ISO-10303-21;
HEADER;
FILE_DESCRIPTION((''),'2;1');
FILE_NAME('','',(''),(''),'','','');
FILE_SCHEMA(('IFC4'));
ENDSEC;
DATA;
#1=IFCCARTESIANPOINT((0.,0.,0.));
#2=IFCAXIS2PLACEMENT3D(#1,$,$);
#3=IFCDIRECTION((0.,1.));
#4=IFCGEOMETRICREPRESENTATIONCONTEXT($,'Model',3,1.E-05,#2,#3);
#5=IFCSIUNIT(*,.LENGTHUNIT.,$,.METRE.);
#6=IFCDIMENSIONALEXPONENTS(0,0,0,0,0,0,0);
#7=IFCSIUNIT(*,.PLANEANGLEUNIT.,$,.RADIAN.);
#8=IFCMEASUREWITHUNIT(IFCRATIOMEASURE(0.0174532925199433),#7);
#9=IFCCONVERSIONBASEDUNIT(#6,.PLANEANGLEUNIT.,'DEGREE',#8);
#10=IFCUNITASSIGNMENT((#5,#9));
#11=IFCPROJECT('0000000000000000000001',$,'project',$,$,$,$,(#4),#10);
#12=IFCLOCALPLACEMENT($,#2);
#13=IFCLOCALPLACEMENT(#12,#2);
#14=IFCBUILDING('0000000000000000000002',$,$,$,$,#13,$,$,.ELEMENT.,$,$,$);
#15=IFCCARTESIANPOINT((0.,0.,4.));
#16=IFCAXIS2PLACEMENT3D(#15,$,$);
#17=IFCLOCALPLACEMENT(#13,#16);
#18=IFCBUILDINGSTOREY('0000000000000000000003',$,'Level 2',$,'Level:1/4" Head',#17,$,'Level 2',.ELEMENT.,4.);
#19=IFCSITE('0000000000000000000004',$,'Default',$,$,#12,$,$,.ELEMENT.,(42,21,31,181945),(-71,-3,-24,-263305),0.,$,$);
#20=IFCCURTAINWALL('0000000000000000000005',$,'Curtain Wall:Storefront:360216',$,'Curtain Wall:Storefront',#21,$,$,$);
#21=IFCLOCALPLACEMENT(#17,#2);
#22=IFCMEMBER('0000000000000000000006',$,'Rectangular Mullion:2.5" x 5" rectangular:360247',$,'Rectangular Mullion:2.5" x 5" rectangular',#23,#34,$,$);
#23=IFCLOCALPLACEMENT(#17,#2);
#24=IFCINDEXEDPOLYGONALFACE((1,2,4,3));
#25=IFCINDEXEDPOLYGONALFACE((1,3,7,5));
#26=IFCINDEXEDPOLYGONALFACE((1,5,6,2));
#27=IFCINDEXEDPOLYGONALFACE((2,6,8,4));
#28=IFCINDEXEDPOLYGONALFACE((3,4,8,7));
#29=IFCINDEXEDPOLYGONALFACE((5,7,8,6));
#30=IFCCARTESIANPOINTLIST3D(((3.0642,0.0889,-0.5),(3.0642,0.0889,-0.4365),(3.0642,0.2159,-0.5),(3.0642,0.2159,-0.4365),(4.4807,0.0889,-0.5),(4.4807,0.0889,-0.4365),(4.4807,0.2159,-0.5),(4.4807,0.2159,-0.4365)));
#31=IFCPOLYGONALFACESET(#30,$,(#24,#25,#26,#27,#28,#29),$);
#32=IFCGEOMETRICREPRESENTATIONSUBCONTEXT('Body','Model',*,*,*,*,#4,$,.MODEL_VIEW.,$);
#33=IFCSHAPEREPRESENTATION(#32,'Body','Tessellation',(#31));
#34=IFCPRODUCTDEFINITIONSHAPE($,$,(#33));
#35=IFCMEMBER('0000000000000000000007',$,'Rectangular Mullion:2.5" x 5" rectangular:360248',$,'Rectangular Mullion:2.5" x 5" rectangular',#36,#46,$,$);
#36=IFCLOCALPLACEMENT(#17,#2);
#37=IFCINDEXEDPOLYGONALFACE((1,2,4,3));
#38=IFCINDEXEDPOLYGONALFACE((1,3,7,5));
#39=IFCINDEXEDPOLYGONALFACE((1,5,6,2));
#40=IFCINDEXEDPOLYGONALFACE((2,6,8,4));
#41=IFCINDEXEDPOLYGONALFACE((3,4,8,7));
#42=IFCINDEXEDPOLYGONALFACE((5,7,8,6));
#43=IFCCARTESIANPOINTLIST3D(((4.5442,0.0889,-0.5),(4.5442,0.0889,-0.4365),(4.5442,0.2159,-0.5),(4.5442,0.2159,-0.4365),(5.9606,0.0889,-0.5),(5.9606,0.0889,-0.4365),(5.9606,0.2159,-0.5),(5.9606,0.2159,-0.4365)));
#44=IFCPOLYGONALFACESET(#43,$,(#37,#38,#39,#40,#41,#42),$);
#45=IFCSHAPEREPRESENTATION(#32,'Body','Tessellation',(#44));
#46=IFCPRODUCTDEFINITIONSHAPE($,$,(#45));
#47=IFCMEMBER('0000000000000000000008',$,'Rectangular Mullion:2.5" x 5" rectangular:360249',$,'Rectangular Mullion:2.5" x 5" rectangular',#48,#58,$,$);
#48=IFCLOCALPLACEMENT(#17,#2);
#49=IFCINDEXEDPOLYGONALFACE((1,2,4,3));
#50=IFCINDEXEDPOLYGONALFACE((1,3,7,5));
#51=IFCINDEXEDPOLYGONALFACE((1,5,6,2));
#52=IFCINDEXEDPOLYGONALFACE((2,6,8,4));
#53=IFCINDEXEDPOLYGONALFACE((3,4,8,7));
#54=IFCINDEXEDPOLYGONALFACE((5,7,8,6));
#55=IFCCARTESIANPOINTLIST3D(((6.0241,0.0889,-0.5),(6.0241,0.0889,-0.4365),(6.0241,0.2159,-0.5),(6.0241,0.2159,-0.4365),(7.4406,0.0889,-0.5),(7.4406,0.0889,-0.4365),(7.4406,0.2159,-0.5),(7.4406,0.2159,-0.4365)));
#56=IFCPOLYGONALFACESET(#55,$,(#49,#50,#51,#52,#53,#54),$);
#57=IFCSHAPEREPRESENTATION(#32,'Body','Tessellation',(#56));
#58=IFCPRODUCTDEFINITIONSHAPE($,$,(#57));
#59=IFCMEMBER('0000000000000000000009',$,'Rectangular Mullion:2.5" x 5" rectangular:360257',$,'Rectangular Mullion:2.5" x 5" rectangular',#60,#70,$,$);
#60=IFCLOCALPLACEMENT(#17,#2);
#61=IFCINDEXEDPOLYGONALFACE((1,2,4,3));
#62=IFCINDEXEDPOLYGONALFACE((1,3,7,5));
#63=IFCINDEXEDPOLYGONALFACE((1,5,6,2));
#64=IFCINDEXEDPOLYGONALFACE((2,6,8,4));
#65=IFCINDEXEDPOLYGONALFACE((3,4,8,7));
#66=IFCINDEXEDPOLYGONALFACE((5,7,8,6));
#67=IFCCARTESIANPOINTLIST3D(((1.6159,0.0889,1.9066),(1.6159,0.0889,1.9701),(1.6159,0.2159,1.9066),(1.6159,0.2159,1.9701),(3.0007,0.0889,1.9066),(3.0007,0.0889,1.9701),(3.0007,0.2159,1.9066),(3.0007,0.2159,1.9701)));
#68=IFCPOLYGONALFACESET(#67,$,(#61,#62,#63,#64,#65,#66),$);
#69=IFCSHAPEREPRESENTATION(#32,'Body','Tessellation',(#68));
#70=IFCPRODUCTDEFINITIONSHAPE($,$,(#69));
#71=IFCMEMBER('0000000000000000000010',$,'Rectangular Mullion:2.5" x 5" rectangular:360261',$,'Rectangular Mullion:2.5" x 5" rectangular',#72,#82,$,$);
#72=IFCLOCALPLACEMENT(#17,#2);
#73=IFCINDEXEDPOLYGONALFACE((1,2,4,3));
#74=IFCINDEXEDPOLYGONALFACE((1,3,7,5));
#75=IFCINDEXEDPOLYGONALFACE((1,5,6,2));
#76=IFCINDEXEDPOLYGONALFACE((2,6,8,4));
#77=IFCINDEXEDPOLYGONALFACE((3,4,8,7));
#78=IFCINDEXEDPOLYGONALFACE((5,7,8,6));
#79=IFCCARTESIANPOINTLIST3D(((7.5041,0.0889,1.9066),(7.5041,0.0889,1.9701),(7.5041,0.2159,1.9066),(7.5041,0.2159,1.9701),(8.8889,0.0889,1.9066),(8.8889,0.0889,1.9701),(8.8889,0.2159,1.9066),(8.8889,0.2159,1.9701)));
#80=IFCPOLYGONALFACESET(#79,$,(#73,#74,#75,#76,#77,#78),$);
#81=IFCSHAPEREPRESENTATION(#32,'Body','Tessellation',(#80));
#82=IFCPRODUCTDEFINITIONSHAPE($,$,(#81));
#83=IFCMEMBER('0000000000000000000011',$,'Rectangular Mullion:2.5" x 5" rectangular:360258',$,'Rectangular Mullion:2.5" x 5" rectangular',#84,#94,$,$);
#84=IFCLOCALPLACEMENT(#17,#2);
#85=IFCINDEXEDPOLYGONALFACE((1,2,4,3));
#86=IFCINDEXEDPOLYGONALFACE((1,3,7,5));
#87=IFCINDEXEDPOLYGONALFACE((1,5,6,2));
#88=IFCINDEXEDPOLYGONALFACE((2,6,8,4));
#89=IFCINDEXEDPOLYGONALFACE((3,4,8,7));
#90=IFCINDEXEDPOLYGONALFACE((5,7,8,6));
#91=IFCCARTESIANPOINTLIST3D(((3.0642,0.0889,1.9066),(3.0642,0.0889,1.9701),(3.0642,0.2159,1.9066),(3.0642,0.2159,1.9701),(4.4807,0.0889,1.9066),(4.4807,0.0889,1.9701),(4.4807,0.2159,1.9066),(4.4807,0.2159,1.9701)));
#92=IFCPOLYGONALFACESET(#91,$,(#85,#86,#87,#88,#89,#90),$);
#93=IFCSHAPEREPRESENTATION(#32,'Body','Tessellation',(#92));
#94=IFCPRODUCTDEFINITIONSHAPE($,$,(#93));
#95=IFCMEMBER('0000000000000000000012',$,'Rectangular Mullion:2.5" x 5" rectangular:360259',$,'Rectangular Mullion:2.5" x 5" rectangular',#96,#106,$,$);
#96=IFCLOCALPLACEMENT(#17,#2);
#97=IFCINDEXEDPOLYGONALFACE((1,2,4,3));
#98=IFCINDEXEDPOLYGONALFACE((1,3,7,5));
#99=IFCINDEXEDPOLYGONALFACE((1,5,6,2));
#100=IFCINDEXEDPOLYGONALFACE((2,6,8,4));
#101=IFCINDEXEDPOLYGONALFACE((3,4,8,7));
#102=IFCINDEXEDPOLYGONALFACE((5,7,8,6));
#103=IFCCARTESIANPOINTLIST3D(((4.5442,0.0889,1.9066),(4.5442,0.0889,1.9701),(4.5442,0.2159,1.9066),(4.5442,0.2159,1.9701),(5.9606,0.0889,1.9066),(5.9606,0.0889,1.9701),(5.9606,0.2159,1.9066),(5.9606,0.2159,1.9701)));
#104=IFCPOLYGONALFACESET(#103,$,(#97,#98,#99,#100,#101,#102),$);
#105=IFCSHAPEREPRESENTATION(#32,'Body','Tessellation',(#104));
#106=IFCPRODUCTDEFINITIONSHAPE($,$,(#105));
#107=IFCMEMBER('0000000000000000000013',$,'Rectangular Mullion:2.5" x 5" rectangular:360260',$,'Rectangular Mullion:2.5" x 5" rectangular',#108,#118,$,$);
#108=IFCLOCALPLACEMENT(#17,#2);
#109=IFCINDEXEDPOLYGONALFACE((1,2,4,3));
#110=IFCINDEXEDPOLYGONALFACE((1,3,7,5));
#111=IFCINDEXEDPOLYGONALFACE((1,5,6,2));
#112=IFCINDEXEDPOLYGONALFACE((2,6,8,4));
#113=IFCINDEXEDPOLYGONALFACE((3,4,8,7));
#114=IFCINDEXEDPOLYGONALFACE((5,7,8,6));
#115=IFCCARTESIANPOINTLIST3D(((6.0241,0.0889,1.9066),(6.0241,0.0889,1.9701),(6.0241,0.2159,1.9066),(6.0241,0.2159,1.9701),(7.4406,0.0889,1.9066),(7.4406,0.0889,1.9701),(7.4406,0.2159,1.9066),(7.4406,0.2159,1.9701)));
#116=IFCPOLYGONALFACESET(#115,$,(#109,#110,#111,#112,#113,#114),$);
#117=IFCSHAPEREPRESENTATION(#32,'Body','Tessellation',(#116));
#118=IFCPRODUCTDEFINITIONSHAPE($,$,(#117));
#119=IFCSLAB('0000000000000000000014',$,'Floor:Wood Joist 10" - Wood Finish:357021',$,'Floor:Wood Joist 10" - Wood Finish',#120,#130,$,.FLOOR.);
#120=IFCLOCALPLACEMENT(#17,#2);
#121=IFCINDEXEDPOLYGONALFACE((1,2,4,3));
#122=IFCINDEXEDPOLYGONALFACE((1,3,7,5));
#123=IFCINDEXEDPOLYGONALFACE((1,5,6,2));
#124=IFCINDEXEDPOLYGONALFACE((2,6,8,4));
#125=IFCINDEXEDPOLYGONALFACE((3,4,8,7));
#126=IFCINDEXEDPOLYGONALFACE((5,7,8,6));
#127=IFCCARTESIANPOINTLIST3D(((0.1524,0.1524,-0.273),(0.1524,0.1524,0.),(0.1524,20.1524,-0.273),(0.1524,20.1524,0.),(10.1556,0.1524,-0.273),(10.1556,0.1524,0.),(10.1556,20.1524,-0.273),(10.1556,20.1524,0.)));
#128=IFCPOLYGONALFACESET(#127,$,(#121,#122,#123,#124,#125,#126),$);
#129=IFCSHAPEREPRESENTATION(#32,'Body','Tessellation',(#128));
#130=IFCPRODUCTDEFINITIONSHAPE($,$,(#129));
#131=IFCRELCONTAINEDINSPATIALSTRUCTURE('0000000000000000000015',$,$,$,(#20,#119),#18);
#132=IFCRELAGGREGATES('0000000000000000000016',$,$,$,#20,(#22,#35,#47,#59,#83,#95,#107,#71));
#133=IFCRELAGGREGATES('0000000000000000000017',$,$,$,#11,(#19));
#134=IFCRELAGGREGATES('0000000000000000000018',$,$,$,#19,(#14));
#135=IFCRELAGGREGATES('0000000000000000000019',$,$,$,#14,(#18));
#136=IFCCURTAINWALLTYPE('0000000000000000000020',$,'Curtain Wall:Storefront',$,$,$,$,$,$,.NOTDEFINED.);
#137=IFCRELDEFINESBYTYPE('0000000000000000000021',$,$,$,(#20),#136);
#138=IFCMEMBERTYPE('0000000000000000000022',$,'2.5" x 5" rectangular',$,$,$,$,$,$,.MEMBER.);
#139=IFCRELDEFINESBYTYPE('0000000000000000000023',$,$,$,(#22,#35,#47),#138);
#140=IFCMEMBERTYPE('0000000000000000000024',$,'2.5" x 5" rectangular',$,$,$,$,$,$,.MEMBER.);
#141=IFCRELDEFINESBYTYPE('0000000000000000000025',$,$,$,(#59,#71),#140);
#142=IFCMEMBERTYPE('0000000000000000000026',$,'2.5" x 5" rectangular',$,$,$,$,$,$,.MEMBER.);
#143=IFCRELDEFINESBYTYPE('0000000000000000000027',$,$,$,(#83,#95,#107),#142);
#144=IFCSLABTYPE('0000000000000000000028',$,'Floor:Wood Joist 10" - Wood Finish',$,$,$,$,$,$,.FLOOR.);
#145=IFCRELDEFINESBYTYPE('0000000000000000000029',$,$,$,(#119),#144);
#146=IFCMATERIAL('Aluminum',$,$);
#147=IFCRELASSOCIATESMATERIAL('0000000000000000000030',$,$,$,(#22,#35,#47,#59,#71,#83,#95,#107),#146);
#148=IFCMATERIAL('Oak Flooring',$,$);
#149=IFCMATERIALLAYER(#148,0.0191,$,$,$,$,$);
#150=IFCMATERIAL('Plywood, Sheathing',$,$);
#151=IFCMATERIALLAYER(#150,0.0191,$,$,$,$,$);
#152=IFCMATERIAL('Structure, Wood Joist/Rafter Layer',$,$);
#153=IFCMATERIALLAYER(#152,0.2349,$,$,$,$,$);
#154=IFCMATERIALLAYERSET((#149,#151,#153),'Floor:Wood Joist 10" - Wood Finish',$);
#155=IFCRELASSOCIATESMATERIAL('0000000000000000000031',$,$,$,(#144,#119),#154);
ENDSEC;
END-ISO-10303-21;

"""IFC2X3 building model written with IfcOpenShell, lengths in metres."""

from ifc_helpers import new_model, entity, si_unit, converted_unit, direction, frame, origin, origin_2d_with_axis, place, context, subcontext, project, spatial, rectangle, extrude, source, transform, mapped, material, layer, layer_set, layer_usage, type_object, type_shapes, element, aggregate, save


model = new_model("IFC2X3")

# Units and contexts
model_context = context("Model", 3, precision=1e-05, world=origin(), true_north=direction((0.0, 1.0)))
body_context = subcontext(model_context, "Body", "Model", "MODEL_VIEW")
ifc_project = project(units=[si_unit("LENGTHUNIT", "METRE"), converted_unit("PLANEANGLEUNIT", "DEGREE", entity("IfcRatioMeasure", 0.0174532925199433), si_unit("PLANEANGLEUNIT", "RADIAN"), dimensions=[0, 0, 0, 0, 0, 0, 0])], contexts=[model_context])

# Site, building, storey
site_placement = place(None, origin())
site = spatial("IfcSite", under=ifc_project, at=site_placement, Name="Default", CompositionType="ELEMENT", RefLatitude=(42, 21, 31, 181945), RefLongitude=(-71, -3, -24, -263305), RefElevation=0.0)
building_placement = place(site_placement, origin())
building = spatial("IfcBuilding", under=site, at=building_placement, CompositionType="ELEMENT")
storey_placement = place(building_placement, frame((0.0, 0.0, 4.0)))
storey = spatial("IfcBuildingStorey", under=building, at=storey_placement, Name="Level 2", ObjectType="Level:1/4\" Head", LongName="Level 2", CompositionType="ELEMENT", Elevation=4.0)

# Curtain wall, members
curtain_wall_type = type_object("IfcCurtainWallType", Name="Curtain Wall:Storefront", PredefinedType="NOTDEFINED")
curtain_wall_placement = place(storey_placement, frame((0.0, 0.0, -4.0)))
curtain_wall = element("IfcCurtainWall", 1, at=curtain_wall_placement, inside=storey, type_object=curtain_wall_type, Name="Curtain Wall:Storefront:360216", ObjectType="Curtain Wall:Storefront")
ifc_material_1 = material(Name="Aluminum")
member_type_1 = type_object("IfcMemberType", Name="2.5\" x 5\" rectangular", PredefinedType="MEMBER")
shared_shape_1 = source(origin(), body_context, "Body", "SweptSolid", [
    extrude(rectangle(XDim=0.127, YDim=0.0635, at=origin_2d_with_axis()), frame((-0.0318, 0.0, -1.4165), z_axis=(0.0, 0.0, 1.0), x_axis=(0.0, -1.0, 0.0)), (0.0, 0.0, 1.0), 1.4165),
])
type_shapes(member_type_1, [shared_shape_1])
member_1_placement = place(storey_placement, frame((3.0642, 0.1524, -0.5), z_axis=(-1.0, 0.0, 0.0), x_axis=(0.0, 0.0, -1.0)))
member_1 = element("IfcMember", 2, at=member_1_placement, type_object=member_type_1, material=ifc_material_1, Name="Rectangular Mullion:2.5\" x 5\" rectangular:360247", ObjectType="Rectangular Mullion:2.5\" x 5\" rectangular", context=body_context, shape_type="MappedRepresentation", body=[
    mapped(shared_shape_1, transform((0.0, 0.0, 0.0), scale=1.0)),
])
member_2_placement = place(storey_placement, frame((4.5442, 0.1524, -0.5), z_axis=(-1.0, 0.0, 0.0), x_axis=(0.0, 0.0, -1.0)))
member_2 = element("IfcMember", 3, at=member_2_placement, type_object=member_type_1, material=ifc_material_1, Name="Rectangular Mullion:2.5\" x 5\" rectangular:360248", ObjectType="Rectangular Mullion:2.5\" x 5\" rectangular", context=body_context, shape_type="MappedRepresentation", body=[
    mapped(shared_shape_1, transform((0.0, 0.0, 0.0), scale=1.0)),
])
member_3_placement = place(storey_placement, frame((6.0241, 0.1524, -0.5), z_axis=(-1.0, 0.0, 0.0), x_axis=(0.0, 0.0, -1.0)))
member_3 = element("IfcMember", 4, at=member_3_placement, type_object=member_type_1, material=ifc_material_1, Name="Rectangular Mullion:2.5\" x 5\" rectangular:360249", ObjectType="Rectangular Mullion:2.5\" x 5\" rectangular", context=body_context, shape_type="MappedRepresentation", body=[
    mapped(shared_shape_1, transform((0.0, 0.0, 0.0), scale=1.0)),
])
member_type_2 = type_object("IfcMemberType", Name="2.5\" x 5\" rectangular", PredefinedType="MEMBER")
shared_shape_2 = source(origin(), body_context, "Body", "SweptSolid", [
    extrude(rectangle(XDim=0.127, YDim=0.0635, at=origin_2d_with_axis()), frame((0.0, 0.0, -1.3848), z_axis=(0.0, 0.0, 1.0), x_axis=(0.0, -1.0, 0.0)), (0.0, 0.0, 1.0), 1.3848),
])
type_shapes(member_type_2, [shared_shape_2])
member_4_placement = place(storey_placement, frame((3.0007, 0.1524, 1.9384), z_axis=(1.0, 0.0, 0.0), x_axis=(0.0, 0.0, 1.0)))
member_4 = element("IfcMember", 5, at=member_4_placement, type_object=member_type_2, material=ifc_material_1, Name="Rectangular Mullion:2.5\" x 5\" rectangular:360257", ObjectType="Rectangular Mullion:2.5\" x 5\" rectangular", context=body_context, shape_type="MappedRepresentation", body=[
    mapped(shared_shape_2, transform((0.0, 0.0, 0.0), scale=1.0)),
])
member_5_placement = place(storey_placement, frame((8.8889, 0.1524, 1.9384), z_axis=(1.0, 0.0, 0.0), x_axis=(0.0, 0.0, 1.0)))
member_5 = element("IfcMember", 6, at=member_5_placement, type_object=member_type_2, material=ifc_material_1, Name="Rectangular Mullion:2.5\" x 5\" rectangular:360261", ObjectType="Rectangular Mullion:2.5\" x 5\" rectangular", context=body_context, shape_type="MappedRepresentation", body=[
    mapped(shared_shape_2, transform((0.0, 0.0, 0.0), scale=1.0)),
])
member_type_3 = type_object("IfcMemberType", Name="2.5\" x 5\" rectangular", PredefinedType="MEMBER")
shared_shape_3 = source(origin(), body_context, "Body", "SweptSolid", [
    extrude(rectangle(XDim=0.127, YDim=0.0635, at=origin_2d_with_axis()), frame((0.0, 0.0, -1.4165), z_axis=(0.0, 0.0, 1.0), x_axis=(0.0, -1.0, 0.0)), (0.0, 0.0, 1.0), 1.4165),
])
type_shapes(member_type_3, [shared_shape_3])
member_6_placement = place(storey_placement, frame((4.4807, 0.1524, 1.9384), z_axis=(1.0, 0.0, 0.0), x_axis=(0.0, 0.0, 1.0)))
member_6 = element("IfcMember", 7, at=member_6_placement, type_object=member_type_3, material=ifc_material_1, Name="Rectangular Mullion:2.5\" x 5\" rectangular:360258", ObjectType="Rectangular Mullion:2.5\" x 5\" rectangular", context=body_context, shape_type="MappedRepresentation", body=[
    mapped(shared_shape_3, transform((0.0, 0.0, 0.0), scale=1.0)),
])
member_7_placement = place(storey_placement, frame((5.9606, 0.1524, 1.9384), z_axis=(1.0, 0.0, 0.0), x_axis=(0.0, 0.0, 1.0)))
member_7 = element("IfcMember", 8, at=member_7_placement, type_object=member_type_3, material=ifc_material_1, Name="Rectangular Mullion:2.5\" x 5\" rectangular:360259", ObjectType="Rectangular Mullion:2.5\" x 5\" rectangular", context=body_context, shape_type="MappedRepresentation", body=[
    mapped(shared_shape_3, transform((0.0, 0.0, 0.0), scale=1.0)),
])
member_8_placement = place(storey_placement, frame((7.4406, 0.1524, 1.9384), z_axis=(1.0, 0.0, 0.0), x_axis=(0.0, 0.0, 1.0)))
member_8 = element("IfcMember", 9, at=member_8_placement, type_object=member_type_3, material=ifc_material_1, Name="Rectangular Mullion:2.5\" x 5\" rectangular:360260", ObjectType="Rectangular Mullion:2.5\" x 5\" rectangular", context=body_context, shape_type="MappedRepresentation", body=[
    mapped(shared_shape_3, transform((0.0, 0.0, 0.0), scale=1.0)),
])

# Slab
ifc_material_2 = material(Name="Oak Flooring")
ifc_layer_1 = layer(ifc_material_2, 0.0191)
ifc_material_3 = material(Name="Plywood, Sheathing")
ifc_layer_2 = layer(ifc_material_3, 0.0191)
ifc_material_4 = material(Name="Structure, Wood Joist/Rafter Layer")
ifc_layer_3 = layer(ifc_material_4, 0.2349)
ifc_layer_set_1 = layer_set([ifc_layer_1, ifc_layer_2, ifc_layer_3], Name="Floor:Wood Joist 10\" - Wood Finish")
ifc_layer_usage_1 = layer_usage(ifc_layer_set_1, "AXIS3", "POSITIVE", 0.0)
slab_type = type_object("IfcSlabType", Name="Floor:Wood Joist 10\" - Wood Finish", PredefinedType="FLOOR", material=ifc_layer_set_1)
slab_placement = place(storey_placement, origin())
element("IfcSlab", 10, at=slab_placement, inside=storey, type_object=slab_type, material=ifc_layer_usage_1, Name="Floor:Wood Joist 10\" - Wood Finish:357021", ObjectType="Floor:Wood Joist 10\" - Wood Finish", PredefinedType="FLOOR", context=body_context, shape_type="SweptSolid", body=[
    extrude(rectangle(XDim=20.0, YDim=10.0032, at=origin_2d_with_axis()), frame((5.154, 10.1524, 0.0), z_axis=(0.0, 0.0, -1.0), x_axis=(0.0, 1.0, 0.0)), (0.0, 0.0, 1.0), 0.2731),
])

aggregate(curtain_wall, [member_1, member_2, member_3, member_4, member_6, member_7, member_8, member_5])

save(model, "model.ifc")
